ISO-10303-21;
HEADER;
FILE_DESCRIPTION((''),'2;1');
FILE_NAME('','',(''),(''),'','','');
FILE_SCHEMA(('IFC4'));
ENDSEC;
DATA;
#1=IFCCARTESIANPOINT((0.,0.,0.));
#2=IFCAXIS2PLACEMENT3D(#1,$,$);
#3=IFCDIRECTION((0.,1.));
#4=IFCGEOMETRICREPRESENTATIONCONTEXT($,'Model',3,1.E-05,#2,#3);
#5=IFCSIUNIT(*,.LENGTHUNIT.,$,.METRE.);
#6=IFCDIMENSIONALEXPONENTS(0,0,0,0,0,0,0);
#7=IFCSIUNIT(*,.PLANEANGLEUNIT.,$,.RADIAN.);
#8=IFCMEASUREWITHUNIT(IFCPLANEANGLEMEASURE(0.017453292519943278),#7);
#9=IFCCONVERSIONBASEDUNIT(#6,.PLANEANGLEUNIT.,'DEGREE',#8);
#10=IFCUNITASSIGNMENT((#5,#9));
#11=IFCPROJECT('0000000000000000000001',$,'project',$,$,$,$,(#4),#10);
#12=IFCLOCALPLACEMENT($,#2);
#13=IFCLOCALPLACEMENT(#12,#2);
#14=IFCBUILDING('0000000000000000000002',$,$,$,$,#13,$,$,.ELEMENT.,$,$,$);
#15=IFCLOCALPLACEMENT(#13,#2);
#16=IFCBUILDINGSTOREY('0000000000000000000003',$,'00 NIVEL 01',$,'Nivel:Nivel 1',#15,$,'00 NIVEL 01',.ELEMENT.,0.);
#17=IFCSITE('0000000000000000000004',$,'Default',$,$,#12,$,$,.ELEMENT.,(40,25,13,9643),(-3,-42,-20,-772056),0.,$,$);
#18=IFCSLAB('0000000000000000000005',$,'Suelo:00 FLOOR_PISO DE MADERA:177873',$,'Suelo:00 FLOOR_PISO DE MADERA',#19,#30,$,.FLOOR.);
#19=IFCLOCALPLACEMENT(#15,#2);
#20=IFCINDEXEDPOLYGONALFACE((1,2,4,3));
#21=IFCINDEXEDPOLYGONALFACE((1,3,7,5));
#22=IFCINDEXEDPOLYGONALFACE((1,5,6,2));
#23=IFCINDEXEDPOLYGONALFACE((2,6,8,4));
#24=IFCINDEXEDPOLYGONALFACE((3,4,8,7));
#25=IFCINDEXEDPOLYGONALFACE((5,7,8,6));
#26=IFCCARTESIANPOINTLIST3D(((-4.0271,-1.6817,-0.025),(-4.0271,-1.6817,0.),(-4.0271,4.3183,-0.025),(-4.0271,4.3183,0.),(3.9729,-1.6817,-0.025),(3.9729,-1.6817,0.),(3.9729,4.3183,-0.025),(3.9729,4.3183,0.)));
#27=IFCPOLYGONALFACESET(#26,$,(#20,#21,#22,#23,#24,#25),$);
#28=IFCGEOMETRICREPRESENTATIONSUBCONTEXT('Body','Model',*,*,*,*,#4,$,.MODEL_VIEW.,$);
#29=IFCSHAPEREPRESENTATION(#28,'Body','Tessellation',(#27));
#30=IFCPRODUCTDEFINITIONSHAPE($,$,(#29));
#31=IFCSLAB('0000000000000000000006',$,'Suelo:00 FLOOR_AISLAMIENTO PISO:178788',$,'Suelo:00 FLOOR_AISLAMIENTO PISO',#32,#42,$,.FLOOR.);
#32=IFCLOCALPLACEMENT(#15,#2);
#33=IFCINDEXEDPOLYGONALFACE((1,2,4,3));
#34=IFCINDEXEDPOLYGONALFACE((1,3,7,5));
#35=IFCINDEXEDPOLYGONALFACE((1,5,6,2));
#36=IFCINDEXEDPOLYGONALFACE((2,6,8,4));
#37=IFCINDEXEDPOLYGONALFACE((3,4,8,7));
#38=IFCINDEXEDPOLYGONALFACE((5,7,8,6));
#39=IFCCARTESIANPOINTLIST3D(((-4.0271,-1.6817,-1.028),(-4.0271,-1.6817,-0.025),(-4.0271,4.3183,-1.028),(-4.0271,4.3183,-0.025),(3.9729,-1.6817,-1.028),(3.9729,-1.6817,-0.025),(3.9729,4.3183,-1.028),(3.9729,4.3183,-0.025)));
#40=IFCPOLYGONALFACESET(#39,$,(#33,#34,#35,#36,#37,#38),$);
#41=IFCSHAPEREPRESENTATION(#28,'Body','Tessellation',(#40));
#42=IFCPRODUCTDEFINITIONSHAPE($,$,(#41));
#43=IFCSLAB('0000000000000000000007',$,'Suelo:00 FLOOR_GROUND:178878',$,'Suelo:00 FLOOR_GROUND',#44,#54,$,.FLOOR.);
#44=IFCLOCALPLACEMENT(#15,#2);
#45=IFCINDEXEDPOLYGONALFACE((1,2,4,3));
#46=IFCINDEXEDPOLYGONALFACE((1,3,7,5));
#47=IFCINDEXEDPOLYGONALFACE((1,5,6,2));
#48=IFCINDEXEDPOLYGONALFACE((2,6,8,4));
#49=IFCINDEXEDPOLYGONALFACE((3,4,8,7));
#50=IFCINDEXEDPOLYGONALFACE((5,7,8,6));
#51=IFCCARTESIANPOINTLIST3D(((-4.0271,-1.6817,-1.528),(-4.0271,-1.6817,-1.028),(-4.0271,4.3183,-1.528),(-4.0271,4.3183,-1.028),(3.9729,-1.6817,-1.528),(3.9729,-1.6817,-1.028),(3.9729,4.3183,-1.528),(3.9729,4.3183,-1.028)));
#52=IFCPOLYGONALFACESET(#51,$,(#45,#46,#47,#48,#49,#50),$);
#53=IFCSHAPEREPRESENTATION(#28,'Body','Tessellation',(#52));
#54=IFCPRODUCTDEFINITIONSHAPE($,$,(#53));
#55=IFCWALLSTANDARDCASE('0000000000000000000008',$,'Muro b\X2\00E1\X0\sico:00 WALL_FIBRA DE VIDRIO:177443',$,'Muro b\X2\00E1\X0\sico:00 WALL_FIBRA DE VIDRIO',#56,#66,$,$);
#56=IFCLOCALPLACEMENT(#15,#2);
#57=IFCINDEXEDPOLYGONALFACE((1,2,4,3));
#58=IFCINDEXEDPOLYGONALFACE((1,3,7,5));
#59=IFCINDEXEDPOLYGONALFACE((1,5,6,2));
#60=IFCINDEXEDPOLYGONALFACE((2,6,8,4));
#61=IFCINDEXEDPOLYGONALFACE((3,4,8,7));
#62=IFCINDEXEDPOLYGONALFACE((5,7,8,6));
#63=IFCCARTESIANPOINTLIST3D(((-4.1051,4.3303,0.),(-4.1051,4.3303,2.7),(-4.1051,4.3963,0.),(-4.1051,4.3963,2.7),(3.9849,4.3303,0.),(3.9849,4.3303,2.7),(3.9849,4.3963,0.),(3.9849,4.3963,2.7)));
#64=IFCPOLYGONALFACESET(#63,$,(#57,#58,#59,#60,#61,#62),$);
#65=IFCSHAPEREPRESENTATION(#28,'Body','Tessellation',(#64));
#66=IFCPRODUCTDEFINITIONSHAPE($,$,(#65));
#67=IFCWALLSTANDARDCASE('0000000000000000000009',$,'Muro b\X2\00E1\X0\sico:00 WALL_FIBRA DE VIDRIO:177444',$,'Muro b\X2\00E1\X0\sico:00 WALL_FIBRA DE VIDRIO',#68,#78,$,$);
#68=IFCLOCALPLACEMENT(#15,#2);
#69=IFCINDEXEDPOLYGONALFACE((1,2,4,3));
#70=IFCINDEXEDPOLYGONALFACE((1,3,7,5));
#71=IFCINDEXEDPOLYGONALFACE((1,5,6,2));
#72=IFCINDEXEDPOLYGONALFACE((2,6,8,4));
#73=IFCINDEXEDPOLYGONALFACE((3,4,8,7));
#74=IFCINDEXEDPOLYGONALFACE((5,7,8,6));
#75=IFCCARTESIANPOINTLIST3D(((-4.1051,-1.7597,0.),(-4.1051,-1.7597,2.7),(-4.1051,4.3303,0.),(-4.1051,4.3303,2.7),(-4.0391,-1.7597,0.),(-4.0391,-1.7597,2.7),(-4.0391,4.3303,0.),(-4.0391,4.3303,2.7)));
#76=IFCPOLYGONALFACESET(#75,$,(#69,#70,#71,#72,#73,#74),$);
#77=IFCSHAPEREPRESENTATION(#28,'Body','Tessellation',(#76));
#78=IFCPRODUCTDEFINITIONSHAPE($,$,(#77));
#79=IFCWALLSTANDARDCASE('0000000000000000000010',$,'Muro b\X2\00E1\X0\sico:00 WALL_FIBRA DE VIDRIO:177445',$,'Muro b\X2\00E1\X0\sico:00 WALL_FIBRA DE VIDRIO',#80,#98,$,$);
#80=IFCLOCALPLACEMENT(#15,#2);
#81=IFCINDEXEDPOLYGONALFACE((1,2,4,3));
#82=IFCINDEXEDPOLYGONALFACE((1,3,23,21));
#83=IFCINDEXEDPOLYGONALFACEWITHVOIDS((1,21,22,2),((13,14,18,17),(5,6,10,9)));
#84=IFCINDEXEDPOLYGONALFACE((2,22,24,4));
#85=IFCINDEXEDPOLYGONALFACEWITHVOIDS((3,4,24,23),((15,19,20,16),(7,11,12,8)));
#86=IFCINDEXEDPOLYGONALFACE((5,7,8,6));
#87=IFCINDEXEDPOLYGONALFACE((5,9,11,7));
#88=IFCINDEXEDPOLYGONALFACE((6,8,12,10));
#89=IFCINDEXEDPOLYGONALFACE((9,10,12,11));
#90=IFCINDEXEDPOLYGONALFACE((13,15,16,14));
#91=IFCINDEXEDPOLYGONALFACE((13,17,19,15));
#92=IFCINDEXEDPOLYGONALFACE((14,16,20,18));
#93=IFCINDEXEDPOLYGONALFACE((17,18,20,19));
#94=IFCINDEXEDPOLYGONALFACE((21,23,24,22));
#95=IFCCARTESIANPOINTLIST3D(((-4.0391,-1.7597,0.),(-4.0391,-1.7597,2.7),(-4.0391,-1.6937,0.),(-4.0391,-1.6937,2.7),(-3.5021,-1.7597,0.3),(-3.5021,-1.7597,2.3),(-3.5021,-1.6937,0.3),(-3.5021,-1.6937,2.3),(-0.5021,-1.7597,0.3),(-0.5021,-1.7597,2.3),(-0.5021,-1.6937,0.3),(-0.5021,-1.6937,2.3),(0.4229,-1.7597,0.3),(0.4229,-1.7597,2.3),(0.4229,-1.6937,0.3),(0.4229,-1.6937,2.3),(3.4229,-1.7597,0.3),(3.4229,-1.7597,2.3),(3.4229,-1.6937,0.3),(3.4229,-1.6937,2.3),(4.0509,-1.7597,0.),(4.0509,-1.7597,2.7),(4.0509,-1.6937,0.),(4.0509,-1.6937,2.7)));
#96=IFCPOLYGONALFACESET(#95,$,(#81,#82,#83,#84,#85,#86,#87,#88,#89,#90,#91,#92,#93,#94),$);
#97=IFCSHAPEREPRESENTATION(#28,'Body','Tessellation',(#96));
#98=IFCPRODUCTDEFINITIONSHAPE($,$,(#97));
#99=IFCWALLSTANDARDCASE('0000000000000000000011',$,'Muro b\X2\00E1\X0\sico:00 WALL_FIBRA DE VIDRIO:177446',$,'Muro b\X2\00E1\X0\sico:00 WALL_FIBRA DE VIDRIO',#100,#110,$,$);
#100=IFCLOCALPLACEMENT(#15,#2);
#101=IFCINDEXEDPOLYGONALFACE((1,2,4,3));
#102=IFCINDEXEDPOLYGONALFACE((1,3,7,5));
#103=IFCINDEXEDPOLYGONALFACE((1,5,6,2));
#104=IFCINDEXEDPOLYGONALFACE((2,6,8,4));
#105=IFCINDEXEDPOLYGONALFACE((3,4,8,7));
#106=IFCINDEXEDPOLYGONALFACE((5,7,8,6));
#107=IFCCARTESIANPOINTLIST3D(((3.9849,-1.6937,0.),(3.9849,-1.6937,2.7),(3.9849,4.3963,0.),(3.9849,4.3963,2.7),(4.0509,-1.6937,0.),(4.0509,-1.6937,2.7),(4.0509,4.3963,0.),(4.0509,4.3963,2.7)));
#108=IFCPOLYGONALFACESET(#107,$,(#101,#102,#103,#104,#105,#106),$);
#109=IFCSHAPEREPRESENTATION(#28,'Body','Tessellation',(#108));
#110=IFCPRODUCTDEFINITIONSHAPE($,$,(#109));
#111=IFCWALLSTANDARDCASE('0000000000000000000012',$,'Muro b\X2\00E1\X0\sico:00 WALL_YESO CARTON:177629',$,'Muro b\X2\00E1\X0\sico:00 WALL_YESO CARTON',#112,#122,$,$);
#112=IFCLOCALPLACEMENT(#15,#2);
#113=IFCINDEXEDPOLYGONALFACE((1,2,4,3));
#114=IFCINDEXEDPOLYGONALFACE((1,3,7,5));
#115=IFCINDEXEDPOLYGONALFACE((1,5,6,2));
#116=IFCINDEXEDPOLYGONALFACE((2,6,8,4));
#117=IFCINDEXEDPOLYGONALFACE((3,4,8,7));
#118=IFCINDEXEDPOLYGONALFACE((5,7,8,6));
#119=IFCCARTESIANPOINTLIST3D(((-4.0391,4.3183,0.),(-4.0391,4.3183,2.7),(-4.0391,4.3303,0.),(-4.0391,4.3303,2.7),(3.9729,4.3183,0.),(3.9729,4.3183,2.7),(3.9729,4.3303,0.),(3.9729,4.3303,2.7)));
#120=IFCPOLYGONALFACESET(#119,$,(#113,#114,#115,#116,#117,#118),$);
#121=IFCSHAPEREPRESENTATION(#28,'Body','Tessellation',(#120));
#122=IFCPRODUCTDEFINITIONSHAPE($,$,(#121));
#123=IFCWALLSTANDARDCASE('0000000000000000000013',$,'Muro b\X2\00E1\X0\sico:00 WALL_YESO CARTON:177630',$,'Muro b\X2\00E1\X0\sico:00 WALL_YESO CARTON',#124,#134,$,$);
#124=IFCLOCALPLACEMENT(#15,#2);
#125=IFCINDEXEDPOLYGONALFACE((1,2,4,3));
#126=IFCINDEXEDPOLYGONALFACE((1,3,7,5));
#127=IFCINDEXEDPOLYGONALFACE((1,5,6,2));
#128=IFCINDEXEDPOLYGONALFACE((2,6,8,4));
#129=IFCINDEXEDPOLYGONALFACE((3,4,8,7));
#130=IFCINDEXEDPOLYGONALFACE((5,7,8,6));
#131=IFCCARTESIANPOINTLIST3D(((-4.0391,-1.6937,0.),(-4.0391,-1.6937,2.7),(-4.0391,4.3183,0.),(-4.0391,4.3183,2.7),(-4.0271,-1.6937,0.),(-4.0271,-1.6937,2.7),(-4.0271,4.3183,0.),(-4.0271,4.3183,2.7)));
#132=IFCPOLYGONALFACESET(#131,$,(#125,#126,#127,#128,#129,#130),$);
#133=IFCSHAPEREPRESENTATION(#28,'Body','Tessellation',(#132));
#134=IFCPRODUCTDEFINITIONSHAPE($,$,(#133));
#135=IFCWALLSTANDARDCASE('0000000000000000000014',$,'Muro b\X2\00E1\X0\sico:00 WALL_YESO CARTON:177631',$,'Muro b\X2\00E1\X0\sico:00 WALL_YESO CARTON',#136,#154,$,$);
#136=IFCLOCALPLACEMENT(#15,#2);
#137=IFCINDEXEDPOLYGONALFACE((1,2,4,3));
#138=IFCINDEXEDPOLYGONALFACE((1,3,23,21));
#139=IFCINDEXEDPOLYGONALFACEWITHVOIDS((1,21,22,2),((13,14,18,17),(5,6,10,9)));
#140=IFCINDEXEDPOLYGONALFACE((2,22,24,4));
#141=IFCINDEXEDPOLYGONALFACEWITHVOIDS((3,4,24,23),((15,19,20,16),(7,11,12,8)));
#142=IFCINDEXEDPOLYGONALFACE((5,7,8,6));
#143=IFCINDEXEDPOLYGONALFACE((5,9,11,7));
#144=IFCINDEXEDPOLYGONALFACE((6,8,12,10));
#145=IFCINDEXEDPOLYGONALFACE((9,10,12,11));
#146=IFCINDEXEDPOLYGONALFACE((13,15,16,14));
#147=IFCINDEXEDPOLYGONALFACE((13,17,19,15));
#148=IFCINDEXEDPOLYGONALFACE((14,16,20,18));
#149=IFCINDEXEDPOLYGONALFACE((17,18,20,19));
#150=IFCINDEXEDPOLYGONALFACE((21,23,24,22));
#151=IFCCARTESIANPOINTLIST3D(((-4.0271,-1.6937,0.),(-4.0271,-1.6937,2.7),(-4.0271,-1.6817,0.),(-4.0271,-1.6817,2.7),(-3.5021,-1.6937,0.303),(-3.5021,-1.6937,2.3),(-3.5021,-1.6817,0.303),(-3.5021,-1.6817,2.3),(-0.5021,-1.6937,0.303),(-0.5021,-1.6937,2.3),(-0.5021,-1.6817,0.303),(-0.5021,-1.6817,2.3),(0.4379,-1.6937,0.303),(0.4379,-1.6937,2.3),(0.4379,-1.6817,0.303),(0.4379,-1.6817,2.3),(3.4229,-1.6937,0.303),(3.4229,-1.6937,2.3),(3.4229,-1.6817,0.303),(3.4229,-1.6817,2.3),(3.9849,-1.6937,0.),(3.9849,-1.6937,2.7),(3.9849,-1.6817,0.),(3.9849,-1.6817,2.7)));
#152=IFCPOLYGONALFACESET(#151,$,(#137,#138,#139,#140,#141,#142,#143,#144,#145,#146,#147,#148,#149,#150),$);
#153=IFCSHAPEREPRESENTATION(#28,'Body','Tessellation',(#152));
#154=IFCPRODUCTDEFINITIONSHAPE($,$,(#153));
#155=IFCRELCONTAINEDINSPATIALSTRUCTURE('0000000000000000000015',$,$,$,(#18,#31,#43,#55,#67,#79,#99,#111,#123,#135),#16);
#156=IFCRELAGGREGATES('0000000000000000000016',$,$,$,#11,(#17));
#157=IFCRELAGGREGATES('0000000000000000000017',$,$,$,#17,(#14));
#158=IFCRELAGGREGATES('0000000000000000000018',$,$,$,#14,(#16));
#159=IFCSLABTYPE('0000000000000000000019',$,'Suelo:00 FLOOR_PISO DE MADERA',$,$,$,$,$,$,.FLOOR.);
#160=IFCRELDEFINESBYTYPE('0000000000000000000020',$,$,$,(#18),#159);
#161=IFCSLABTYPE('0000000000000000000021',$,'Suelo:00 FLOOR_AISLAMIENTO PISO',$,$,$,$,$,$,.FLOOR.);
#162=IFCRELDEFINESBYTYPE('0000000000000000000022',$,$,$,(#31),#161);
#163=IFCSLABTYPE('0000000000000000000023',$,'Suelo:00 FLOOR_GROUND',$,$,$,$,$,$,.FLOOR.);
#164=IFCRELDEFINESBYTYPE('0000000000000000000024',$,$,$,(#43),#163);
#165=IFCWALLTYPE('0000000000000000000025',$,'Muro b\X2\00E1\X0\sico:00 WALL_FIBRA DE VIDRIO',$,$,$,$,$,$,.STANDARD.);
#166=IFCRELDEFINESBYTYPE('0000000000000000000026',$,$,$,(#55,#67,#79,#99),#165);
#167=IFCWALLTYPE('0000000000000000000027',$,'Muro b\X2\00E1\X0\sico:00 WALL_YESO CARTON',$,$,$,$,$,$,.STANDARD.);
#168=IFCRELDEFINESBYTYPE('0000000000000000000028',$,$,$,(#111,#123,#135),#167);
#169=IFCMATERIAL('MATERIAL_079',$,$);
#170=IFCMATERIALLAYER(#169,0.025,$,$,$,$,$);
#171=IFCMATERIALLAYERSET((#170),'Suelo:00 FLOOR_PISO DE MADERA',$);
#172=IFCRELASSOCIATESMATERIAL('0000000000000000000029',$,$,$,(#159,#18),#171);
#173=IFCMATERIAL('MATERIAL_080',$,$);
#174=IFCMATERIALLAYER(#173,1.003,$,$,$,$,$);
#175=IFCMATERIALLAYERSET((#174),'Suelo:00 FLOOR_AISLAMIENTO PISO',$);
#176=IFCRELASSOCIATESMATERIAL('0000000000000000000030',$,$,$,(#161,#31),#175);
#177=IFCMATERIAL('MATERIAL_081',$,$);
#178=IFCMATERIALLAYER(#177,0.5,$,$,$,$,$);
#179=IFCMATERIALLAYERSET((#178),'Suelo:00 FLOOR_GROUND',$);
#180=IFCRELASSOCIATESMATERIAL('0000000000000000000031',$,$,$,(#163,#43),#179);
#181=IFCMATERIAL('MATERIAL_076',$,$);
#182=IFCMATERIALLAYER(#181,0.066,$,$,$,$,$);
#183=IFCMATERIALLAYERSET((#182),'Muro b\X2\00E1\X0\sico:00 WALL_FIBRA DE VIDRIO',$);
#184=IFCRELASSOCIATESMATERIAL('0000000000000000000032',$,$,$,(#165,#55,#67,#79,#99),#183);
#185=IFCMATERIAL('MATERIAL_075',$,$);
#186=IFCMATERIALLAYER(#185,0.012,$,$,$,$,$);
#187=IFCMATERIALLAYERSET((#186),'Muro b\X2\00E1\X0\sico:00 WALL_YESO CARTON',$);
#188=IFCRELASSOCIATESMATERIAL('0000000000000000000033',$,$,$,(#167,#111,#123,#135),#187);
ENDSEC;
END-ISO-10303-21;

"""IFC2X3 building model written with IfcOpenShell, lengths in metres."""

from ifc_helpers import new_model, entity, si_unit, converted_unit, direction, frame, frame_2d, origin, origin_2d_with_axis, place, context, subcontext, project, spatial, rectangle, extrude, material, layer, layer_set, layer_usage, type_object, element, save


model = new_model("IFC2X3")

# Units and contexts
model_context = context("Model", 3, precision=1e-05, world=origin(), true_north=direction((0.0, 1.0)))
body_context = subcontext(model_context, "Body", "Model", "MODEL_VIEW")
ifc_project = project(units=[si_unit("LENGTHUNIT", "METRE"), converted_unit("PLANEANGLEUNIT", "DEGREE", entity("IfcPlaneAngleMeasure", 0.017453292519943278), si_unit("PLANEANGLEUNIT", "RADIAN"), dimensions=[0, 0, 0, 0, 0, 0, 0])], contexts=[model_context])

# Site, building, storey
site_placement = place(None, origin())
site = spatial("IfcSite", under=ifc_project, at=site_placement, Name="Default", CompositionType="ELEMENT", RefLatitude=(40, 25, 13, 9643), RefLongitude=(-3, -42, -20, -772056), RefElevation=0.0)
building_placement = place(site_placement, origin())
building = spatial("IfcBuilding", under=site, at=building_placement, CompositionType="ELEMENT")
storey_placement = place(building_placement, origin())
storey = spatial("IfcBuildingStorey", under=building, at=storey_placement, Name="00 NIVEL 01", ObjectType="Nivel:Nivel 1", LongName="00 NIVEL 01", CompositionType="ELEMENT", Elevation=0.0)

# Slabs
ifc_material_1 = material(Name="MATERIAL_079")
ifc_layer_1 = layer(ifc_material_1, 0.025)
ifc_layer_set_1 = layer_set([ifc_layer_1], Name="Suelo:00 FLOOR_PISO DE MADERA")
ifc_layer_usage_1 = layer_usage(ifc_layer_set_1, "AXIS3", "POSITIVE", 0.0)
slab_type_1 = type_object("IfcSlabType", Name="Suelo:00 FLOOR_PISO DE MADERA", PredefinedType="FLOOR", material=ifc_layer_set_1)
slab_1_placement = place(storey_placement, origin())
element("IfcSlab", 1, at=slab_1_placement, inside=storey, type_object=slab_type_1, material=ifc_layer_usage_1, Name="Suelo:00 FLOOR_PISO DE MADERA:177873", ObjectType="Suelo:00 FLOOR_PISO DE MADERA", PredefinedType="FLOOR", context=body_context, shape_type="SweptSolid", body=[
    extrude(rectangle(XDim=6.0, YDim=8.0, at=origin_2d_with_axis()), frame((-0.0271, 1.3183, 0.0), z_axis=(0.0, 0.0, -1.0), x_axis=(0.0, 1.0, 0.0)), (0.0, 0.0, 1.0), 0.025),
])
ifc_material_2 = material(Name="MATERIAL_080")
ifc_layer_2 = layer(ifc_material_2, 1.003)
ifc_layer_set_2 = layer_set([ifc_layer_2], Name="Suelo:00 FLOOR_AISLAMIENTO PISO")
ifc_layer_usage_2 = layer_usage(ifc_layer_set_2, "AXIS3", "POSITIVE", 0.0)
slab_type_2 = type_object("IfcSlabType", Name="Suelo:00 FLOOR_AISLAMIENTO PISO", PredefinedType="FLOOR", material=ifc_layer_set_2)
slab_2_placement = place(storey_placement, origin())
element("IfcSlab", 2, at=slab_2_placement, inside=storey, type_object=slab_type_2, material=ifc_layer_usage_2, Name="Suelo:00 FLOOR_AISLAMIENTO PISO:178788", ObjectType="Suelo:00 FLOOR_AISLAMIENTO PISO", PredefinedType="FLOOR", context=body_context, shape_type="SweptSolid", body=[
    extrude(rectangle(XDim=6.0, YDim=8.0, at=origin_2d_with_axis()), frame((-0.0271, 1.3183, -0.025), z_axis=(0.0, 0.0, -1.0), x_axis=(0.0, 1.0, 0.0)), (0.0, 0.0, 1.0), 1.003),
])
ifc_material_3 = material(Name="MATERIAL_081")
ifc_layer_3 = layer(ifc_material_3, 0.5)
ifc_layer_set_3 = layer_set([ifc_layer_3], Name="Suelo:00 FLOOR_GROUND")
ifc_layer_usage_3 = layer_usage(ifc_layer_set_3, "AXIS3", "POSITIVE", 0.0)
slab_type_3 = type_object("IfcSlabType", Name="Suelo:00 FLOOR_GROUND", PredefinedType="FLOOR", material=ifc_layer_set_3)
slab_3_placement = place(storey_placement, origin())
element("IfcSlab", 3, at=slab_3_placement, inside=storey, type_object=slab_type_3, material=ifc_layer_usage_3, Name="Suelo:00 FLOOR_GROUND:178878", ObjectType="Suelo:00 FLOOR_GROUND", PredefinedType="FLOOR", context=body_context, shape_type="SweptSolid", body=[
    extrude(rectangle(XDim=6.0, YDim=8.0, at=origin_2d_with_axis()), frame((-0.0271, 1.3183, -1.028), z_axis=(0.0, 0.0, -1.0), x_axis=(0.0, 1.0, 0.0)), (0.0, 0.0, 1.0), 0.5),
])

# Walls
ifc_material_4 = material(Name="MATERIAL_076")
ifc_layer_4 = layer(ifc_material_4, 0.066)
ifc_layer_set_4 = layer_set([ifc_layer_4], Name="Muro básico:00 WALL_FIBRA DE VIDRIO")
ifc_layer_usage_4 = layer_usage(ifc_layer_set_4, "AXIS2", "NEGATIVE", 0.033)
wall_type_1 = type_object("IfcWallType", Name="Muro básico:00 WALL_FIBRA DE VIDRIO", PredefinedType="STANDARD", material=ifc_layer_set_4)
wall_1_placement = place(storey_placement, frame((-4.1051, 4.3633, 0.0)))
element("IfcWallStandardCase", 4, at=wall_1_placement, inside=storey, type_object=wall_type_1, material=ifc_layer_usage_4, Name="Muro básico:00 WALL_FIBRA DE VIDRIO:177443", ObjectType="Muro básico:00 WALL_FIBRA DE VIDRIO", context=body_context, shape_type="SweptSolid", body=[
    extrude(rectangle(XDim=8.09, YDim=0.066, at=frame_2d((4.045, 0.0), x_axis=(-1.0, 0.0))), origin(), (0.0, 0.0, 1.0), 2.7),
])
ifc_layer_usage_5 = layer_usage(ifc_layer_set_4, "AXIS2", "NEGATIVE", 0.033)
wall_2_placement = place(storey_placement, frame((-4.0721, -1.7597, 0.0), z_axis=(0.0, 0.0, 1.0), x_axis=(0.0, 1.0, 0.0)))
element("IfcWallStandardCase", 5, at=wall_2_placement, inside=storey, type_object=wall_type_1, material=ifc_layer_usage_5, Name="Muro básico:00 WALL_FIBRA DE VIDRIO:177444", ObjectType="Muro básico:00 WALL_FIBRA DE VIDRIO", context=body_context, shape_type="SweptSolid", body=[
    extrude(rectangle(XDim=6.09, YDim=0.066, at=frame_2d((3.045, 0.0), x_axis=(-1.0, 0.0))), origin(), (0.0, 0.0, 1.0), 2.7),
])

# Wall, openings
ifc_layer_usage_6 = layer_usage(ifc_layer_set_4, "AXIS2", "NEGATIVE", 0.033)
wall_3_placement = place(storey_placement, frame((4.0509, -1.7267, 0.0), z_axis=(0.0, 0.0, 1.0), x_axis=(-1.0, 0.0, 0.0)))
wall_3 = element("IfcWallStandardCase", 6, at=wall_3_placement, inside=storey, type_object=wall_type_1, material=ifc_layer_usage_6, Name="Muro básico:00 WALL_FIBRA DE VIDRIO:177445", ObjectType="Muro básico:00 WALL_FIBRA DE VIDRIO", context=body_context, shape_type="SweptSolid", body=[
    extrude(rectangle(XDim=8.09, YDim=0.066, at=frame_2d((4.045, 0.0), x_axis=(-1.0, 0.0))), origin(), (0.0, 0.0, 1.0), 2.7),
])
opening_1_placement = place(wall_3_placement, frame((4.553, -0.033, 0.3)))
element("IfcOpeningElement", 7, at=opening_1_placement, cuts=wall_3, ObjectType="Opening", context=body_context, shape_type="SweptSolid", body=[
    extrude(rectangle(XDim=2.0, YDim=3.0, at=frame_2d((1.0, 1.5), x_axis=(1.0, 0.0))), frame((0.0, 0.0, 0.0), z_axis=(0.0, 1.0, 0.0), x_axis=(0.0, 0.0, 1.0)), (0.0, 0.0, 1.0), 0.066),
])
opening_2_placement = place(wall_3_placement, frame((3.628, 0.033, 0.3)))
element("IfcOpeningElement", 8, at=opening_2_placement, cuts=wall_3, ObjectType="Opening", context=body_context, shape_type="SweptSolid", body=[
    extrude(rectangle(XDim=2.0, YDim=3.0, at=frame_2d((1.0, 1.5), x_axis=(1.0, 0.0))), frame((0.0, 0.0, 0.0), z_axis=(0.0, -1.0, 0.0), x_axis=(0.0, 0.0, 1.0)), (0.0, 0.0, 1.0), 0.066),
])

# Walls
ifc_layer_usage_7 = layer_usage(ifc_layer_set_4, "AXIS2", "NEGATIVE", 0.033)
wall_4_placement = place(storey_placement, frame((4.0179, 4.3963, 0.0), z_axis=(0.0, 0.0, 1.0), x_axis=(0.0, -1.0, 0.0)))
element("IfcWallStandardCase", 9, at=wall_4_placement, inside=storey, type_object=wall_type_1, material=ifc_layer_usage_7, Name="Muro básico:00 WALL_FIBRA DE VIDRIO:177446", ObjectType="Muro básico:00 WALL_FIBRA DE VIDRIO", context=body_context, shape_type="SweptSolid", body=[
    extrude(rectangle(XDim=6.09, YDim=0.066, at=frame_2d((3.045, 0.0), x_axis=(-1.0, 0.0))), origin(), (0.0, 0.0, 1.0), 2.7),
])
ifc_material_5 = material(Name="MATERIAL_075")
ifc_layer_5 = layer(ifc_material_5, 0.012)
ifc_layer_set_5 = layer_set([ifc_layer_5], Name="Muro básico:00 WALL_YESO CARTON")
ifc_layer_usage_8 = layer_usage(ifc_layer_set_5, "AXIS2", "NEGATIVE", 0.006)
wall_type_2 = type_object("IfcWallType", Name="Muro básico:00 WALL_YESO CARTON", PredefinedType="STANDARD", material=ifc_layer_set_5)
wall_5_placement = place(storey_placement, frame((-4.0391, 4.3243, 0.0)))
element("IfcWallStandardCase", 10, at=wall_5_placement, inside=storey, type_object=wall_type_2, material=ifc_layer_usage_8, Name="Muro básico:00 WALL_YESO CARTON:177629", ObjectType="Muro básico:00 WALL_YESO CARTON", context=body_context, shape_type="SweptSolid", body=[
    extrude(rectangle(XDim=8.012, YDim=0.012, at=frame_2d((4.006, 0.0), x_axis=(-1.0, 0.0))), origin(), (0.0, 0.0, 1.0), 2.7),
])
ifc_layer_usage_9 = layer_usage(ifc_layer_set_5, "AXIS2", "NEGATIVE", 0.006)
wall_6_placement = place(storey_placement, frame((-4.0331, -1.6937, 0.0), z_axis=(0.0, 0.0, 1.0), x_axis=(0.0, 1.0, 0.0)))
element("IfcWallStandardCase", 11, at=wall_6_placement, inside=storey, type_object=wall_type_2, material=ifc_layer_usage_9, Name="Muro básico:00 WALL_YESO CARTON:177630", ObjectType="Muro básico:00 WALL_YESO CARTON", context=body_context, shape_type="SweptSolid", body=[
    extrude(rectangle(XDim=6.012, YDim=0.012, at=frame_2d((3.006, 0.0), x_axis=(-1.0, 0.0))), origin(), (0.0, 0.0, 1.0), 2.7),
])

# Wall, openings
ifc_layer_usage_10 = layer_usage(ifc_layer_set_5, "AXIS2", "NEGATIVE", 0.006)
wall_7_placement = place(storey_placement, frame((3.9849, -1.6877, 0.0), z_axis=(0.0, 0.0, 1.0), x_axis=(-1.0, 0.0, 0.0)))
wall_7 = element("IfcWallStandardCase", 12, at=wall_7_placement, inside=storey, type_object=wall_type_2, material=ifc_layer_usage_10, Name="Muro básico:00 WALL_YESO CARTON:177631", ObjectType="Muro básico:00 WALL_YESO CARTON", context=body_context, shape_type="SweptSolid", body=[
    extrude(rectangle(XDim=8.012, YDim=0.012, at=frame_2d((4.006, 0.0), x_axis=(-1.0, 0.0))), origin(), (0.0, 0.0, 1.0), 2.7),
])
opening_3_placement = place(wall_7_placement, origin())
element("IfcOpeningElement", 13, at=opening_3_placement, cuts=wall_7, ObjectType="Opening", context=body_context, shape_type="SweptSolid", body=[
    extrude(rectangle(XDim=1.997, YDim=2.985, at=frame_2d((0.0, 0.0), x_axis=(1.0, 0.0))), frame((2.0545, 0.006, 1.3015), z_axis=(0.0, -1.0, 0.0), x_axis=(0.0, 0.0, 1.0)), (0.0, 0.0, 1.0), 0.012),
])
opening_4_placement = place(wall_7_placement, origin())
element("IfcOpeningElement", 14, at=opening_4_placement, cuts=wall_7, ObjectType="Opening", context=body_context, shape_type="SweptSolid", body=[
    extrude(rectangle(XDim=1.997, YDim=3.0, at=frame_2d((0.0, 0.0), x_axis=(1.0, 0.0))), frame((5.987, 0.006, 1.3015), z_axis=(0.0, -1.0, 0.0), x_axis=(0.0, 0.0, -1.0)), (0.0, 0.0, 1.0), 0.012),
])

save(model, "model.ifc")
